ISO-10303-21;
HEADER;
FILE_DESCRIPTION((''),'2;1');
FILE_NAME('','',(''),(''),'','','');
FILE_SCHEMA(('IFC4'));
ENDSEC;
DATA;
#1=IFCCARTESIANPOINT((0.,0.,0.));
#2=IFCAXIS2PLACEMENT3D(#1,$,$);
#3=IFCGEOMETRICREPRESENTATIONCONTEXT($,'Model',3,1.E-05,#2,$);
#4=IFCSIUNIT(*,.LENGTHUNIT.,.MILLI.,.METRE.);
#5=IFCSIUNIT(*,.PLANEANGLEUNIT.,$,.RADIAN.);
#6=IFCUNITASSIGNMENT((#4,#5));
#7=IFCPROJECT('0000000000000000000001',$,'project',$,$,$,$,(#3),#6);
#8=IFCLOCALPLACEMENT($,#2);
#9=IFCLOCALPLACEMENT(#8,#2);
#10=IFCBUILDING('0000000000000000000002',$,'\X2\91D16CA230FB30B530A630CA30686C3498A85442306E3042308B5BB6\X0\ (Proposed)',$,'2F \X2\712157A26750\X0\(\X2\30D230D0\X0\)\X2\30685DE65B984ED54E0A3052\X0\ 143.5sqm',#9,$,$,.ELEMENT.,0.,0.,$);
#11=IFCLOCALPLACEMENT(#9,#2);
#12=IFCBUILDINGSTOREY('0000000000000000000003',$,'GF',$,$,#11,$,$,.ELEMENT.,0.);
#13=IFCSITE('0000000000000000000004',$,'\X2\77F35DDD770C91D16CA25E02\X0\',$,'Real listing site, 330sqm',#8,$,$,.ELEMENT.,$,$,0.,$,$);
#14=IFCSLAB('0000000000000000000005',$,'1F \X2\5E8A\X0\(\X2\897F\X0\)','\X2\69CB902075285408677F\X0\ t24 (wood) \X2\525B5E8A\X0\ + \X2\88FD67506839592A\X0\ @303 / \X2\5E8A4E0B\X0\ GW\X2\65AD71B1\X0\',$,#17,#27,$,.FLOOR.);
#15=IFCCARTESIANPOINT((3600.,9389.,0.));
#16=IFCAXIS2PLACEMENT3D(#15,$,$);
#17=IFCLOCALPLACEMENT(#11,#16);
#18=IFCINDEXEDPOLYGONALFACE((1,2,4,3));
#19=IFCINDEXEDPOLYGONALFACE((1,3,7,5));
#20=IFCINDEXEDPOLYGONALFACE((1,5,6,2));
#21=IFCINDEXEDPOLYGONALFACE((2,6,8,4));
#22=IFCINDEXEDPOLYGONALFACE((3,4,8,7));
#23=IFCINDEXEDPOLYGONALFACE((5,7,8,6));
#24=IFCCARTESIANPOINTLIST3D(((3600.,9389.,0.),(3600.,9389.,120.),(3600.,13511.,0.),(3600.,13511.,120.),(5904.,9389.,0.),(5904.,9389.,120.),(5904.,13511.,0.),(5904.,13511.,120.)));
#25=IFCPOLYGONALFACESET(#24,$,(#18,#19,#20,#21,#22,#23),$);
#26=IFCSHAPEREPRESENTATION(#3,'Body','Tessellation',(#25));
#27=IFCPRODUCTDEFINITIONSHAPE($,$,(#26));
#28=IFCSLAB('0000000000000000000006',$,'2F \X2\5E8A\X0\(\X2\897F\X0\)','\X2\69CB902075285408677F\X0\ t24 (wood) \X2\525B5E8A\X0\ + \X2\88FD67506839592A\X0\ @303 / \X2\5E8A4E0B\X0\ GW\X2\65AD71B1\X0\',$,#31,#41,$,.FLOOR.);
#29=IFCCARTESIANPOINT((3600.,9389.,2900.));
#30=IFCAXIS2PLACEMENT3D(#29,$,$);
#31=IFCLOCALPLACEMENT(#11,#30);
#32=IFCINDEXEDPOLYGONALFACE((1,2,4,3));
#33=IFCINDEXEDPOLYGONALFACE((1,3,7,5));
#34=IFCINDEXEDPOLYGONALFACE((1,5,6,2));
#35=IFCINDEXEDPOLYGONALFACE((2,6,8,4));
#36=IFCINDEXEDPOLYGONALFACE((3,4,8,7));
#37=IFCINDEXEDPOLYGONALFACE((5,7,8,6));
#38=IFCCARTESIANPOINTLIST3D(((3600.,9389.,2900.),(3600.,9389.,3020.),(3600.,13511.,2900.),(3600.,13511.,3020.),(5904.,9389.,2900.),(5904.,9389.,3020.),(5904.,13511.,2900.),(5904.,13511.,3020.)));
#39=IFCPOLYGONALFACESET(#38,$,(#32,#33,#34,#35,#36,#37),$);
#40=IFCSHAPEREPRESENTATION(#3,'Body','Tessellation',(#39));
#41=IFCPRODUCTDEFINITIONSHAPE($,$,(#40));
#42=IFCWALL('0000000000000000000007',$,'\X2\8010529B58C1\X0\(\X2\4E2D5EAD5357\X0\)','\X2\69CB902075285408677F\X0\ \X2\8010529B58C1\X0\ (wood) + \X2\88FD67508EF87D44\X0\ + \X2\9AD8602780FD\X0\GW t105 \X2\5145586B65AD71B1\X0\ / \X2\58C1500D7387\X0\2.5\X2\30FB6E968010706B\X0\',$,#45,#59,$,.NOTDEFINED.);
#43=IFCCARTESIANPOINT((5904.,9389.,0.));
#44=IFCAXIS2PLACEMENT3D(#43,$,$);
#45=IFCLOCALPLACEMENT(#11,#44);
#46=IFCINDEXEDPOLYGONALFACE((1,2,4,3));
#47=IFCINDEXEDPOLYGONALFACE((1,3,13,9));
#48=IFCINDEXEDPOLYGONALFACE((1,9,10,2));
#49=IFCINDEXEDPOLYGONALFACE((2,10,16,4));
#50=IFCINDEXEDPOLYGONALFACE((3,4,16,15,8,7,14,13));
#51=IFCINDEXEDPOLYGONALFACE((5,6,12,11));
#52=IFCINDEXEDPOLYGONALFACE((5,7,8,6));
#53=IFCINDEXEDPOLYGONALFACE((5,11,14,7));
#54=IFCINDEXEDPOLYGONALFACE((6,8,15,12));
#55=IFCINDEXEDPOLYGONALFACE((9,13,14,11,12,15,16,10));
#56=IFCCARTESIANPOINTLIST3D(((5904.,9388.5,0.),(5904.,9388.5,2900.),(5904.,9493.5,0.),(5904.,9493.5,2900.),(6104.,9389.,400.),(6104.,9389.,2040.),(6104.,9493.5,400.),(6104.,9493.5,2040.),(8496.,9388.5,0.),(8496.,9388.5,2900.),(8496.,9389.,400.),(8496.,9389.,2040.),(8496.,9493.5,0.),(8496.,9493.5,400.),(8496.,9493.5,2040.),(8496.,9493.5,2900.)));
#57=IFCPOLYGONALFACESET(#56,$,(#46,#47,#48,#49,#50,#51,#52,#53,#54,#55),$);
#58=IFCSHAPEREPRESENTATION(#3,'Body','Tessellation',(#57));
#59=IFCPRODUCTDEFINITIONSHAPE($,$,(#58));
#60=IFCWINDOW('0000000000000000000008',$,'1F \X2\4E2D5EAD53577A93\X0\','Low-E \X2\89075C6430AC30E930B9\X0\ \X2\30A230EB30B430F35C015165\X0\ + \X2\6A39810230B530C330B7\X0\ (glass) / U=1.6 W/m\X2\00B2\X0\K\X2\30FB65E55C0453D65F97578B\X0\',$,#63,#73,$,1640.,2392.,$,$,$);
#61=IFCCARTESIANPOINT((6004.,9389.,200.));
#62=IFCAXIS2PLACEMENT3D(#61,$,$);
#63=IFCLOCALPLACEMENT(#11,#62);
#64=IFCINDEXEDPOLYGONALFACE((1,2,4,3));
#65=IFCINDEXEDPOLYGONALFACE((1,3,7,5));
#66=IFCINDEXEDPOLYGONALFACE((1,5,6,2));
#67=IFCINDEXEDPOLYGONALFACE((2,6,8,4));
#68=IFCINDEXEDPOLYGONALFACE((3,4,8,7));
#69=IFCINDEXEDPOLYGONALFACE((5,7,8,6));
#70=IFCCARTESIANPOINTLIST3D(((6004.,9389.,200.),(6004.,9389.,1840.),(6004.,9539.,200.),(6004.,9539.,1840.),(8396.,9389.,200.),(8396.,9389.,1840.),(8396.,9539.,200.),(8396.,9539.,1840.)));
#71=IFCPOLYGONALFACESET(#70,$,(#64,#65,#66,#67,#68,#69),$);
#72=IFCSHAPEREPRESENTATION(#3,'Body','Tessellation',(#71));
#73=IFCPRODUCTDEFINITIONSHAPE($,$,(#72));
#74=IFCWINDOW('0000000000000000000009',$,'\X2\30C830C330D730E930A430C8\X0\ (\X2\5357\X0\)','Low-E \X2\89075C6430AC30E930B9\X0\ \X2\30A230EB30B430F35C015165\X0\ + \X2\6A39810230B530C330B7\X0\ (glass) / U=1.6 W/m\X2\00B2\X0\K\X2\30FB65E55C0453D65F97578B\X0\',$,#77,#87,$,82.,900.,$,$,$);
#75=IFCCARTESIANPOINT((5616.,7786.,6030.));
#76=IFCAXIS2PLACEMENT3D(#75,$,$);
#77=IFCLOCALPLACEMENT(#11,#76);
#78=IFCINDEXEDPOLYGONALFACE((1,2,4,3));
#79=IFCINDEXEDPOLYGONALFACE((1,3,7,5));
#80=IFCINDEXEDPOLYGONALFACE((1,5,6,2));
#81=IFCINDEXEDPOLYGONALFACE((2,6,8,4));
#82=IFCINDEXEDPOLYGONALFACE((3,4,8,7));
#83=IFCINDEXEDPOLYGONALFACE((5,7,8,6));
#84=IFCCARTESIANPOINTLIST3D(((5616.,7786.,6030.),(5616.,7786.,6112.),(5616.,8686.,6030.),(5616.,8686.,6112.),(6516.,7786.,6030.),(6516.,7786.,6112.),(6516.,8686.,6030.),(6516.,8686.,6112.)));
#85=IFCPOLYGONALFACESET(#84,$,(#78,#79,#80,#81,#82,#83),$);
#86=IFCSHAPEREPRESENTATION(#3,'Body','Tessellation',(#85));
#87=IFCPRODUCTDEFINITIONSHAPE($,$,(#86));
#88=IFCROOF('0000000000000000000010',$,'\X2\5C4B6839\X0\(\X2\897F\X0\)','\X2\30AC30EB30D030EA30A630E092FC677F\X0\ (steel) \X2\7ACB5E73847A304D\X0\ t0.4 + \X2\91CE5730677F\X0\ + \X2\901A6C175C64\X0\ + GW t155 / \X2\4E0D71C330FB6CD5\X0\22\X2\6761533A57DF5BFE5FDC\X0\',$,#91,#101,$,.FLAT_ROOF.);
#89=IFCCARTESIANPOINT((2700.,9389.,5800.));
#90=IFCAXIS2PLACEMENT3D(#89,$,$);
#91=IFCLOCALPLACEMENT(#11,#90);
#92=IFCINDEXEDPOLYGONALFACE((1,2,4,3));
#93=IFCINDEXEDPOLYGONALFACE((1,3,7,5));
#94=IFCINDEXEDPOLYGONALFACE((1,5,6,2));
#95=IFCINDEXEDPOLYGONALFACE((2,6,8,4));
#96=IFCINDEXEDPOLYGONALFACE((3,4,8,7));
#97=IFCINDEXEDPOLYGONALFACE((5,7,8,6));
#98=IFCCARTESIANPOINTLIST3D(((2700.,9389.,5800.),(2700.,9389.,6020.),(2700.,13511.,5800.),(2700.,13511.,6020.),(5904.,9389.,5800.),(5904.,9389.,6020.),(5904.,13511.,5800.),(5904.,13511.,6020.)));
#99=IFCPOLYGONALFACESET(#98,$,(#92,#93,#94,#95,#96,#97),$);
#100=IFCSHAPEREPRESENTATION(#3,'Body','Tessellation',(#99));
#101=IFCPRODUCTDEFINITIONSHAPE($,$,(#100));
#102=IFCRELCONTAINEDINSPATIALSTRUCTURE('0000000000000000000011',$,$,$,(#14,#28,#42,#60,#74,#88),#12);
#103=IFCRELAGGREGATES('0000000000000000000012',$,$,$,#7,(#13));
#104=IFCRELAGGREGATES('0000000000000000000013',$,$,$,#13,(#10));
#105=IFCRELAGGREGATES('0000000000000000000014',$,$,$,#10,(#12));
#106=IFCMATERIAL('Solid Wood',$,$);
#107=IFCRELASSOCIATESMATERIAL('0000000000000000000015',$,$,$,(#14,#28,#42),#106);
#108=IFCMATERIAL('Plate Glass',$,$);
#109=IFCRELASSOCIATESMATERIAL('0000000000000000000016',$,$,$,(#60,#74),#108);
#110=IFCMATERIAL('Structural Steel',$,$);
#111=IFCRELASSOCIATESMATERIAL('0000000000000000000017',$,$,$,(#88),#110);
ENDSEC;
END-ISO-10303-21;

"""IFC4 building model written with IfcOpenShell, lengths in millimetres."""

from ifc_helpers import new_model, si_unit, frame, frame_2d, origin, place, context, project, spatial, rectangle, extrude, material, element, fill, save


model = new_model("IFC4")

# Units and contexts
model_context = context("Model", 3, precision=1e-05, world=origin())
ifc_project = project(units=[si_unit("LENGTHUNIT", "METRE", prefix="MILLI"), si_unit("PLANEANGLEUNIT", "RADIAN")], contexts=[model_context])

# Site, building, storey
site_placement = place(None, origin())
site = spatial("IfcSite", under=ifc_project, at=site_placement, Name="石川県金沢市", ObjectType="Real listing site, 330sqm", CompositionType="ELEMENT", RefElevation=0.0)
building_placement = place(site_placement, origin())
building = spatial("IfcBuilding", under=site, at=building_placement, Name="金沢・サウナと水風呂のある家 (Proposed)", ObjectType="2F 無垢材(ヒバ)と左官仕上げ 143.5sqm", CompositionType="ELEMENT", ElevationOfRefHeight=0.0, ElevationOfTerrain=0.0)
storey_placement = place(building_placement, origin())
storey = spatial("IfcBuildingStorey", under=building, at=storey_placement, Name="GF", CompositionType="ELEMENT", Elevation=0.0)

# Shared definitions
ifc_material_1 = material(Name="Solid Wood")

# Slabs
slab_1_placement = place(storey_placement, frame((3600.0, 9389.0, 0.0)))
element("IfcSlab", 1, at=slab_1_placement, inside=storey, material=ifc_material_1, Name="1F 床(西)", Description="構造用合板 t24 (wood) 剛床 + 製材根太 @303 / 床下 GW断熱", PredefinedType="FLOOR", context=model_context, shape_type="SweptSolid", body=[
    extrude(rectangle(XDim=2304.0, YDim=4122.0, at=frame_2d((1152.0, 2061.0))), frame((3600.0, 9389.0, 0.0)), (0.0, 0.0, 1.0), 120.0),
])
slab_2_placement = place(storey_placement, frame((3600.0, 9389.0, 2900.0)))
element("IfcSlab", 2, at=slab_2_placement, inside=storey, material=ifc_material_1, Name="2F 床(西)", Description="構造用合板 t24 (wood) 剛床 + 製材根太 @303 / 床下 GW断熱", PredefinedType="FLOOR", context=model_context, shape_type="SweptSolid", body=[
    extrude(rectangle(XDim=2304.0, YDim=4122.0, at=frame_2d((1152.0, 2061.0))), frame((3600.0, 9389.0, 2900.0)), (0.0, 0.0, 1.0), 120.0),
])

# Wall, opening, window
wall_1_placement = place(storey_placement, frame((5904.0, 9389.0, 0.0)))
wall_1 = element("IfcWall", 3, at=wall_1_placement, inside=storey, material=ifc_material_1, Name="耐力壁(中庭南)", Description="構造用合板 耐力壁 (wood) + 製材軸組 + 高性能GW t105 充填断熱 / 壁倍率2.5・準耐火", PredefinedType="NOTDEFINED", context=model_context, shape_type="SweptSolid", body=[
    extrude(rectangle(XDim=2592.0, YDim=105.0, at=frame_2d((1296.0, 52.0))), frame((5904.0, 9389.0, 0.0)), (0.0, 0.0, 1.0), 2900.0),
])
opening_placement = place(storey_placement, frame((6004.0, 9389.0, 200.0)))
opening = element("IfcOpeningElement", 4, at=opening_placement, cuts=wall_1, PredefinedType="NOTDEFINED", context=model_context, shape_type="SweptSolid", body=[
    extrude(rectangle(XDim=2392.0, YDim=150.0, at=frame_2d((1196.0, 75.0))), frame((6004.0, 9389.0, 200.0)), (0.0, 0.0, 1.0), 1640.0),
])
ifc_material_2 = material(Name="Plate Glass")
window_1_placement = place(storey_placement, frame((6004.0, 9389.0, 200.0)))
window_1 = element("IfcWindow", 5, at=window_1_placement, inside=storey, material=ifc_material_2, Name="1F 中庭南窓", Description="Low-E 複層ガラス アルゴン封入 + 樹脂サッシ (glass) / U=1.6 W/m²K・日射取得型", OverallHeight=1640.0, OverallWidth=2392.0, context=model_context, shape_type="SweptSolid", body=[
    extrude(rectangle(XDim=2392.0, YDim=150.0, at=frame_2d((1196.0, 75.0))), frame((6004.0, 9389.0, 200.0)), (0.0, 0.0, 1.0), 1640.0),
])
fill(opening, window_1)

# Window
window_2_placement = place(storey_placement, frame((5616.0, 7786.0, 6030.0)))
element("IfcWindow", 6, at=window_2_placement, inside=storey, material=ifc_material_2, Name="トップライト (南)", Description="Low-E 複層ガラス アルゴン封入 + 樹脂サッシ (glass) / U=1.6 W/m²K・日射取得型", OverallHeight=82.0, OverallWidth=900.0, context=model_context, shape_type="SweptSolid", body=[
    extrude(rectangle(XDim=900.0, YDim=900.0, at=frame_2d((450.0, 450.0))), frame((5616.0, 7786.0, 6030.0)), (0.0, 0.0, 1.0), 82.0),
])

# Roof
ifc_material_3 = material(Name="Structural Steel")
for number, where, name in (
    (7, (2700.0, 9389.0, 5800.0), "屋根(西)"),
):
    element("IfcRoof", number, at=place(storey_placement, frame(where)), inside=storey, material=ifc_material_3, Name=name, Description="ガルバリウム鋼板 (steel) 立平葺き t0.4 + 野地板 + 通気層 + GW t155 / 不燃・法22条区域対応", PredefinedType="FLAT_ROOF", context=model_context, shape_type="SweptSolid", body=[
        extrude(rectangle(XDim=3204.0, YDim=4122.0, at=frame_2d((1602.0, 2061.0))), frame((2700.0, 9389.0, 5800.0)), (0.0, 0.0, 1.0), 220.0),
    ])

save(model, "model.ifc")
